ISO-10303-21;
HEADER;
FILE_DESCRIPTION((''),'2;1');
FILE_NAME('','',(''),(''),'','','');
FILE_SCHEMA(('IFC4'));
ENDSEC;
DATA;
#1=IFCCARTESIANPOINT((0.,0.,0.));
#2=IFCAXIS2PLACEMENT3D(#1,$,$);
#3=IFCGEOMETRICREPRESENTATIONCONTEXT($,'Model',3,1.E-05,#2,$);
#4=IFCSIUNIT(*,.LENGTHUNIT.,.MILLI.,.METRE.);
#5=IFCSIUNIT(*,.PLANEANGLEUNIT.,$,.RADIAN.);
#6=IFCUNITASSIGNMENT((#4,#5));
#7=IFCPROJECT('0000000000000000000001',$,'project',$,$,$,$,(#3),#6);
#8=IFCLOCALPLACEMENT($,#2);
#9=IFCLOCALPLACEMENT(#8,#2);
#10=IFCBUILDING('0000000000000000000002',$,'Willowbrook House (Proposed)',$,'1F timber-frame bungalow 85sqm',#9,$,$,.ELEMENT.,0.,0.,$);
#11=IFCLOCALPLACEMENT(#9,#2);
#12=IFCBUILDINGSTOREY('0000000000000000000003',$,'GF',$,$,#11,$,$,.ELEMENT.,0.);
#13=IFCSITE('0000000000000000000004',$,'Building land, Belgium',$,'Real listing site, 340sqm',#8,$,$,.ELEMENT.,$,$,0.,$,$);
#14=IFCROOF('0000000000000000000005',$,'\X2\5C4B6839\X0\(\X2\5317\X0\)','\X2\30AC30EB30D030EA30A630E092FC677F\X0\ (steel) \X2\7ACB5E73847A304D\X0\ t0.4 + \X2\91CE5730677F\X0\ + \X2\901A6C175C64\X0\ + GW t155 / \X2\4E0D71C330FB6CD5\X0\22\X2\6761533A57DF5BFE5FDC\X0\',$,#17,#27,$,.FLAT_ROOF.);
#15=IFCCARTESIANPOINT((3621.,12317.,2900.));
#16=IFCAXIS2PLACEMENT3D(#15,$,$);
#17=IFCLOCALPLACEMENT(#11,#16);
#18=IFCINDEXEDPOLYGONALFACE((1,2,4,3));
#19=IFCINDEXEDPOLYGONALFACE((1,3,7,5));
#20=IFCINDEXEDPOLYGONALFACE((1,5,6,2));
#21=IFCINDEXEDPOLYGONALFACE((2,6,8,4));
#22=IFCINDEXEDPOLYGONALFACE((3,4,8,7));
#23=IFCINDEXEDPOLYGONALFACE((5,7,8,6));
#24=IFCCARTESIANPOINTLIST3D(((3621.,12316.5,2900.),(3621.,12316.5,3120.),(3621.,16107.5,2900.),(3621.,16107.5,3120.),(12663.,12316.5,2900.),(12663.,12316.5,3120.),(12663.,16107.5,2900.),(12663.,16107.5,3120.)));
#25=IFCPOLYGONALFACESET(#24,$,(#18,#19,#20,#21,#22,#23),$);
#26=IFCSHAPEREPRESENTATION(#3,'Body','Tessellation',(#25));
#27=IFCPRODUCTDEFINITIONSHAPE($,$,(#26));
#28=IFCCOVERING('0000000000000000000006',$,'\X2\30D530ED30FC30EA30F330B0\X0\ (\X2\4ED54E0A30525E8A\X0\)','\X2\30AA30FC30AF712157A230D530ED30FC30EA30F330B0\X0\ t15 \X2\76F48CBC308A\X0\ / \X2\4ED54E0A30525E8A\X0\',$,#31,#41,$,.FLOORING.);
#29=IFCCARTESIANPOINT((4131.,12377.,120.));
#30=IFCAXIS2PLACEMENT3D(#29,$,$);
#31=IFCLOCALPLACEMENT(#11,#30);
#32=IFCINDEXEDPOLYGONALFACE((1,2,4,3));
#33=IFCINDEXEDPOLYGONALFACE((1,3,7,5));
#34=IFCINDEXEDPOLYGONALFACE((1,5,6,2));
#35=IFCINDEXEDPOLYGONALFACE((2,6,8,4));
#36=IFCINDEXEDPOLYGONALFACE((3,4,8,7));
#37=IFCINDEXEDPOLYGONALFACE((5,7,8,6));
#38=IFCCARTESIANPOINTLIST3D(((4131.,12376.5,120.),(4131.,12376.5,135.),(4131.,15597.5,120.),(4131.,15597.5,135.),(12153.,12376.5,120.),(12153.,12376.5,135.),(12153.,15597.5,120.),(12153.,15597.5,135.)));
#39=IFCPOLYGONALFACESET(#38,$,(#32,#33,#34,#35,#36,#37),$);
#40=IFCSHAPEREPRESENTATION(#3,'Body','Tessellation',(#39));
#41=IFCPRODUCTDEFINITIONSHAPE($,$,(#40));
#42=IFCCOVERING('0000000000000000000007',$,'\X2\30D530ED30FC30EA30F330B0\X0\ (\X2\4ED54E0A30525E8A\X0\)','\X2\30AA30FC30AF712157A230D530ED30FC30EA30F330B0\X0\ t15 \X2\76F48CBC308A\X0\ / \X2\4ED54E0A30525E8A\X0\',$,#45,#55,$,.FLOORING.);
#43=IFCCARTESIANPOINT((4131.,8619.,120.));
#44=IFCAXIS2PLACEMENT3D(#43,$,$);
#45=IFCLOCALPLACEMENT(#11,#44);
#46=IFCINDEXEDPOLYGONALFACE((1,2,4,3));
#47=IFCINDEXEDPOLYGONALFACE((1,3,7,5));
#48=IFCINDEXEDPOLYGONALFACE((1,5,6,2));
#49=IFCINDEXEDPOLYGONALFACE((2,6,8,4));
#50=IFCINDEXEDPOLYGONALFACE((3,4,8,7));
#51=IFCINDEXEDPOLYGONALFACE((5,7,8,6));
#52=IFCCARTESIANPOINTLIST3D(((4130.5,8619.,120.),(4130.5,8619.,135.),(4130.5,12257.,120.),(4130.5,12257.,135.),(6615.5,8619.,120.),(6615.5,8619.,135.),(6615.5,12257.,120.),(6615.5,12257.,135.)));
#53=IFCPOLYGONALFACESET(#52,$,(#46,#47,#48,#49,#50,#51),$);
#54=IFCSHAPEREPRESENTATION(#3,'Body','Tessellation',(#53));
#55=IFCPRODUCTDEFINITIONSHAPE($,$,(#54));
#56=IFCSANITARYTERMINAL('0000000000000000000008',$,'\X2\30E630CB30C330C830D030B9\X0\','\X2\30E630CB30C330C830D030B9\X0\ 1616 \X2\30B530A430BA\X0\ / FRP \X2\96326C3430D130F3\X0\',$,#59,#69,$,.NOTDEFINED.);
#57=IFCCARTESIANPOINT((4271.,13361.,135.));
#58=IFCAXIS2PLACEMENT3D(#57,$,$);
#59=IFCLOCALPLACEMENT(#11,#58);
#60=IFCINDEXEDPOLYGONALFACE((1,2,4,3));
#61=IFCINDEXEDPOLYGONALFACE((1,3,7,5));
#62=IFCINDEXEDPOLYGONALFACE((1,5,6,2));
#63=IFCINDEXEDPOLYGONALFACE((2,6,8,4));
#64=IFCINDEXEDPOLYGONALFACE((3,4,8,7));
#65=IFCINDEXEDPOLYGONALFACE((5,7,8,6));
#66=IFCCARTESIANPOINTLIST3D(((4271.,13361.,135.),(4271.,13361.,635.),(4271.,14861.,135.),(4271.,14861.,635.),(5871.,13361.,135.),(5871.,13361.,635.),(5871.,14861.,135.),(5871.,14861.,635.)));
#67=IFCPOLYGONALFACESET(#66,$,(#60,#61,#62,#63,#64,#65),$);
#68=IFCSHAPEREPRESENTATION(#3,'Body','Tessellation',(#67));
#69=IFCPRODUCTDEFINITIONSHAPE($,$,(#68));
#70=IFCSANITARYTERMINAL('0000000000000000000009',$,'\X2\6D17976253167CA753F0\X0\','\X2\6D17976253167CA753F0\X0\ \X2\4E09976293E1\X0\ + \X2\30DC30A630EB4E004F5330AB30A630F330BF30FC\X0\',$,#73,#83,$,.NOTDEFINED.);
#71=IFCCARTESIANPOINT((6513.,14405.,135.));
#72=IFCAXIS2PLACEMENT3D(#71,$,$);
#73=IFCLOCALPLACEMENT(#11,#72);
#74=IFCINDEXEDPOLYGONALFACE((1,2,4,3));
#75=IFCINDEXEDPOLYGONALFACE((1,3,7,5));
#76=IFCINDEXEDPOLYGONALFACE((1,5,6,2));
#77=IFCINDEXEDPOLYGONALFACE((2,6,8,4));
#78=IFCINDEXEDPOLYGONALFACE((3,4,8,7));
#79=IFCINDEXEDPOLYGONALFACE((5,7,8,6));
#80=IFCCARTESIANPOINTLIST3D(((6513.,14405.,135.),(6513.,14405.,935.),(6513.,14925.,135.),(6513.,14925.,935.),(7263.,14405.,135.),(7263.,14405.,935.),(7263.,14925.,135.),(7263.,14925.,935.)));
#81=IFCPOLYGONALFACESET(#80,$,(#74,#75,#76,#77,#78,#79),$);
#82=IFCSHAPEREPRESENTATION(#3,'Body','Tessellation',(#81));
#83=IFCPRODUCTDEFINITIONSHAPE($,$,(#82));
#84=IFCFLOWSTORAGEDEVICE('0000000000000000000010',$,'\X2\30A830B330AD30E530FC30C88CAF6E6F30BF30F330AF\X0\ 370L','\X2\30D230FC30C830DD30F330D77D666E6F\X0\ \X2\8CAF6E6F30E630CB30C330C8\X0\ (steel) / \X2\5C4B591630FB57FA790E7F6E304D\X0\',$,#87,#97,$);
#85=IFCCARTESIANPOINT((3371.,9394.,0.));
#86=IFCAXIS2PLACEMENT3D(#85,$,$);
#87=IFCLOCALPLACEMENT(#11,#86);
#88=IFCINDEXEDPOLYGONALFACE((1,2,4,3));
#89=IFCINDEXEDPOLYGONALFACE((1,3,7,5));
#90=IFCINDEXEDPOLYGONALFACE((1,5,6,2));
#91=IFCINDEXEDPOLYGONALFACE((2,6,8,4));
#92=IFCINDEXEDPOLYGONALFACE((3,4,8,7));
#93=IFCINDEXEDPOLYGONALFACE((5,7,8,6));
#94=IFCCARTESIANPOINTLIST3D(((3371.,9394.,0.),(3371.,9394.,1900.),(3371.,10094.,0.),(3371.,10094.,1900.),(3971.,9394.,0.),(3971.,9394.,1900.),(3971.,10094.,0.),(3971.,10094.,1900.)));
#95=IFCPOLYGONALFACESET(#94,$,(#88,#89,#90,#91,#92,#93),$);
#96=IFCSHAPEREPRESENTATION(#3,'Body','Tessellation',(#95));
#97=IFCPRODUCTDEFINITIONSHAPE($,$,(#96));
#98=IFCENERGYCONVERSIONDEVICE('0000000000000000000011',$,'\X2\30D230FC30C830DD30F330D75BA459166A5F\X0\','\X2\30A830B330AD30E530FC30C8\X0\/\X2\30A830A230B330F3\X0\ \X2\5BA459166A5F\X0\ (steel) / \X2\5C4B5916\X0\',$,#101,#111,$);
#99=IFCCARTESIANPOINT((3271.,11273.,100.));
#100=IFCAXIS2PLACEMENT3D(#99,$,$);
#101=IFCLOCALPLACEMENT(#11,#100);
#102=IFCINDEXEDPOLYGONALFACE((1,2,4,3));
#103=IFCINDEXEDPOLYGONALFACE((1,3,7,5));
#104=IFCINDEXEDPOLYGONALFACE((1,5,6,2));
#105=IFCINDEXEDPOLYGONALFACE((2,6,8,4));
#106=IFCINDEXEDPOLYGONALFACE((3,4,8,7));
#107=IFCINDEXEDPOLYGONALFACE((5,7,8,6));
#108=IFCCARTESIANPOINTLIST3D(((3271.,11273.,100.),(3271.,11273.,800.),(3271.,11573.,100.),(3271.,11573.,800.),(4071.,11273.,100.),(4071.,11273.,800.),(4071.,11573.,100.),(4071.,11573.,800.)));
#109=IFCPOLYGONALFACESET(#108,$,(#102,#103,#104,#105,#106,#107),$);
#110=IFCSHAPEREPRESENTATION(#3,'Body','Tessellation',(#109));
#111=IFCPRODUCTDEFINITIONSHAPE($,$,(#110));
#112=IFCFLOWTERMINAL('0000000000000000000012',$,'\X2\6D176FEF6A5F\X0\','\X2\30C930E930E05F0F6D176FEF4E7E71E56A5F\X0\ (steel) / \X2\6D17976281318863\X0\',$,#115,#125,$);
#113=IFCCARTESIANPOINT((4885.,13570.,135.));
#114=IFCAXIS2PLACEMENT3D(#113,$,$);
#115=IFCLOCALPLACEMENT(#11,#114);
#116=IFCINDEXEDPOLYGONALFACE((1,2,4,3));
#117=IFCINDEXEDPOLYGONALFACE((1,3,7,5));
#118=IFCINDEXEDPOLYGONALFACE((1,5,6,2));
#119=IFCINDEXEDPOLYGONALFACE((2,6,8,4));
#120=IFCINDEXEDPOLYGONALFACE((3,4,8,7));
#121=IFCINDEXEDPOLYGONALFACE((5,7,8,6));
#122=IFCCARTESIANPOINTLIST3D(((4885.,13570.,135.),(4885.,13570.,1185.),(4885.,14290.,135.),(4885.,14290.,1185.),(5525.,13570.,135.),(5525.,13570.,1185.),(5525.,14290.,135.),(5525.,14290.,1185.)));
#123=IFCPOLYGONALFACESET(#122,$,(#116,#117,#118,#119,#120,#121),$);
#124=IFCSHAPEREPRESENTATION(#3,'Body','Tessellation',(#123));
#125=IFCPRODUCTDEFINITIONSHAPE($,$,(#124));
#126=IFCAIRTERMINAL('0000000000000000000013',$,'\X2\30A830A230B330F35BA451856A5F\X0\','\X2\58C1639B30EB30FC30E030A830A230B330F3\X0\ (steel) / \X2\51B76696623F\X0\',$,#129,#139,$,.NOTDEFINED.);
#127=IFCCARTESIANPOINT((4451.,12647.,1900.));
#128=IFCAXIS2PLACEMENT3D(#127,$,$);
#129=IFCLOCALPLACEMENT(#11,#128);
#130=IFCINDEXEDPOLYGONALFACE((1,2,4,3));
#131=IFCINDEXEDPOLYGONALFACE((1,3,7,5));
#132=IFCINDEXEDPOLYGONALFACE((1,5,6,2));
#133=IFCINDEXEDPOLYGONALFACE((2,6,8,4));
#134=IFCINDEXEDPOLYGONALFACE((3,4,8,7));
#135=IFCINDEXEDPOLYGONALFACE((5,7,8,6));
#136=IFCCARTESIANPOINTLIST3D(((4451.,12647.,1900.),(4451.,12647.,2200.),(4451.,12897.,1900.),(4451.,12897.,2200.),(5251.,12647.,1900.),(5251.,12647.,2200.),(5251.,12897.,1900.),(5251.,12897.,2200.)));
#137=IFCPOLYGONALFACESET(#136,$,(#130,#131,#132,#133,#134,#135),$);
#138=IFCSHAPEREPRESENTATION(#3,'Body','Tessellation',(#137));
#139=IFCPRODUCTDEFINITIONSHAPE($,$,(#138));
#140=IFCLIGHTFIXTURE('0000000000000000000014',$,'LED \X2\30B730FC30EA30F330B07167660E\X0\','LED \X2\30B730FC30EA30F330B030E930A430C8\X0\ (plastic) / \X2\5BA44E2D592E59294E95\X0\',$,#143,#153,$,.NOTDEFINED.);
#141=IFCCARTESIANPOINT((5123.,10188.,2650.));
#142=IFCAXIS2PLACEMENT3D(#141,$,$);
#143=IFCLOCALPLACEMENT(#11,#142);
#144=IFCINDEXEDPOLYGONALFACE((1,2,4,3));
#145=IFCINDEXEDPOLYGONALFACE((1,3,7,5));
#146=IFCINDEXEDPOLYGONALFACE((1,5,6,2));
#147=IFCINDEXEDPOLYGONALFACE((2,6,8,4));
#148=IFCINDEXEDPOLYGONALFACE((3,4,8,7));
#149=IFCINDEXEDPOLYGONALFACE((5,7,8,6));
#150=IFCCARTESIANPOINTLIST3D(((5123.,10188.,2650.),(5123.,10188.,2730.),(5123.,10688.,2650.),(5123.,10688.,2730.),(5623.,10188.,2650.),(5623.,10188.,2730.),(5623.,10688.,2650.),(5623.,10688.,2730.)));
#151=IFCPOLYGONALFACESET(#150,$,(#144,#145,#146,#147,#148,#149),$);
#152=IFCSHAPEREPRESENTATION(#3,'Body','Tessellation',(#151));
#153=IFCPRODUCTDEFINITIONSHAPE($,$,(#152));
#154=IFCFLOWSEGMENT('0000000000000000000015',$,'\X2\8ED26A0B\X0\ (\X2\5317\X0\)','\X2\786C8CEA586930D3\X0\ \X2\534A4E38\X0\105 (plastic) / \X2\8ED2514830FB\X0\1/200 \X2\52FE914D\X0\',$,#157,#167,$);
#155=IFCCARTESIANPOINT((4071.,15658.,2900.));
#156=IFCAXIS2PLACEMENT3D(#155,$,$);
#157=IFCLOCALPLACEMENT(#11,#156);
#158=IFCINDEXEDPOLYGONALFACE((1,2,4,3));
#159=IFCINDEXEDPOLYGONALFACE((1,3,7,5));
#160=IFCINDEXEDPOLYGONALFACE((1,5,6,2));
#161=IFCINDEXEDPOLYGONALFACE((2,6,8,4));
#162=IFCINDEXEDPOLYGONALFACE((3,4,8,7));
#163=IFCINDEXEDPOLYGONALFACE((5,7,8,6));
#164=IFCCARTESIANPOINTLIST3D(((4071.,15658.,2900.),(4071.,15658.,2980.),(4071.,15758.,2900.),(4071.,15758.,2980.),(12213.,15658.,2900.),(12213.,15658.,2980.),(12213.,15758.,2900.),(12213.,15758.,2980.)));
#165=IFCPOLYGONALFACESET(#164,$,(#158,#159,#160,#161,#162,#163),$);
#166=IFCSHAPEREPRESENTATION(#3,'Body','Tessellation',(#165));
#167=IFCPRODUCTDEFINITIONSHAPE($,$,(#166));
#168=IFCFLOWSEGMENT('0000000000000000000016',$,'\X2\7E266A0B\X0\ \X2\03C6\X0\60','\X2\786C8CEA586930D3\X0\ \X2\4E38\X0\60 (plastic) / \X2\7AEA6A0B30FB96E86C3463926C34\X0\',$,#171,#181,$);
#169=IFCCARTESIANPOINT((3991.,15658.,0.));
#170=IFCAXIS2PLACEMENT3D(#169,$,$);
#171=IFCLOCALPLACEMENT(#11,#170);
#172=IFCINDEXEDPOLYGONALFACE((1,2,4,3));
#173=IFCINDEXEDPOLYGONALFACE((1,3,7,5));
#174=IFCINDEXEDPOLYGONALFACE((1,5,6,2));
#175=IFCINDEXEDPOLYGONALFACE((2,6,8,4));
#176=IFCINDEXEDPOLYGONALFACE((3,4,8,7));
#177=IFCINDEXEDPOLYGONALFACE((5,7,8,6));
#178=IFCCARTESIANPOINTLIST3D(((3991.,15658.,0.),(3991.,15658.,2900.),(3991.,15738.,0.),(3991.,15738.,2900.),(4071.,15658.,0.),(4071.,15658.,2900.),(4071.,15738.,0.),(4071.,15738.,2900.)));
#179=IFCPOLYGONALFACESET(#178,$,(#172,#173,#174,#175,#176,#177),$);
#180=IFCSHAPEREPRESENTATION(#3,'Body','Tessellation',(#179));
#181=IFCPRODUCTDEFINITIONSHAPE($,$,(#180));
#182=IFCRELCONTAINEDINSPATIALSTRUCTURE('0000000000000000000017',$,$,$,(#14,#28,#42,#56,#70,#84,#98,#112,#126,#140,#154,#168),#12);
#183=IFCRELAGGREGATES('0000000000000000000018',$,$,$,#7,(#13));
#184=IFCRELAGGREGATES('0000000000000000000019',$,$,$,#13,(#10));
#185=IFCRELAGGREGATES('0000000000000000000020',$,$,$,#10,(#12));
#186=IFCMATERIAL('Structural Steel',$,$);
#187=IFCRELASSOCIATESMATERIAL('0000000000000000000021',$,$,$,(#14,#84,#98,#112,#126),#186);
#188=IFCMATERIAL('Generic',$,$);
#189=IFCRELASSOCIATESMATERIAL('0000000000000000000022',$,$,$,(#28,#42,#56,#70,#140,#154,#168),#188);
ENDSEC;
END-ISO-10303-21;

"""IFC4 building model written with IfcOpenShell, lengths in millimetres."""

from ifc_helpers import new_model, si_unit, frame, frame_2d, origin, place, context, project, spatial, rectangle, extrude, material, element, save


model = new_model("IFC4")

# Units and contexts
model_context = context("Model", 3, precision=1e-05, world=origin())
ifc_project = project(units=[si_unit("LENGTHUNIT", "METRE", prefix="MILLI"), si_unit("PLANEANGLEUNIT", "RADIAN")], contexts=[model_context])

# Site, building, storey
site_placement = place(None, origin())
site = spatial("IfcSite", under=ifc_project, at=site_placement, Name="Building land, Belgium", ObjectType="Real listing site, 340sqm", CompositionType="ELEMENT", RefElevation=0.0)
building_placement = place(site_placement, origin())
building = spatial("IfcBuilding", under=site, at=building_placement, Name="Willowbrook House (Proposed)", ObjectType="1F timber-frame bungalow 85sqm", CompositionType="ELEMENT", ElevationOfRefHeight=0.0, ElevationOfTerrain=0.0)
storey_placement = place(building_placement, origin())
storey = spatial("IfcBuildingStorey", under=building, at=storey_placement, Name="GF", CompositionType="ELEMENT", Elevation=0.0)

# Roof
ifc_material_1 = material(Name="Structural Steel")
roof_placement = place(storey_placement, frame((3621.0, 12317.0, 2900.0)))
element("IfcRoof", 1, at=roof_placement, inside=storey, material=ifc_material_1, Name="屋根(北)", Description="ガルバリウム鋼板 (steel) 立平葺き t0.4 + 野地板 + 通気層 + GW t155 / 不燃・法22条区域対応", PredefinedType="FLAT_ROOF", context=model_context, shape_type="SweptSolid", body=[
    extrude(rectangle(XDim=9042.0, YDim=3791.0, at=frame_2d((4521.0, 1895.0))), frame((3621.0, 12317.0, 2900.0)), (0.0, 0.0, 1.0), 220.0),
])

# Coverings
ifc_material_2 = material(Name="Generic")
covering_1_placement = place(storey_placement, frame((4131.0, 12377.0, 120.0)))
element("IfcCovering", 2, at=covering_1_placement, inside=storey, material=ifc_material_2, Name="フローリング (仕上げ床)", Description="オーク無垢フローリング t15 直貼り / 仕上げ床", PredefinedType="FLOORING", context=model_context, shape_type="SweptSolid", body=[
    extrude(rectangle(XDim=8022.0, YDim=3221.0, at=frame_2d((4011.0, 1610.0))), frame((4131.0, 12377.0, 120.0)), (0.0, 0.0, 1.0), 15.0),
])
covering_2_placement = place(storey_placement, frame((4131.0, 8619.0, 120.0)))
element("IfcCovering", 3, at=covering_2_placement, inside=storey, material=ifc_material_2, Name="フローリング (仕上げ床)", Description="オーク無垢フローリング t15 直貼り / 仕上げ床", PredefinedType="FLOORING", context=model_context, shape_type="SweptSolid", body=[
    extrude(rectangle(XDim=2485.0, YDim=3638.0, at=frame_2d((1242.0, 1819.0))), frame((4131.0, 8619.0, 120.0)), (0.0, 0.0, 1.0), 15.0),
])

# Sanitary terminals
sanitary_terminal_1_placement = place(storey_placement, frame((4271.0, 13361.0, 135.0)))
element("IfcSanitaryTerminal", 4, at=sanitary_terminal_1_placement, inside=storey, material=ifc_material_2, Name="ユニットバス", Description="ユニットバス 1616 サイズ / FRP 防水パン", PredefinedType="NOTDEFINED", context=model_context, shape_type="SweptSolid", body=[
    extrude(rectangle(XDim=1600.0, YDim=1500.0, at=frame_2d((800.0, 750.0))), frame((4271.0, 13361.0, 135.0)), (0.0, 0.0, 1.0), 500.0),
])
sanitary_terminal_2_placement = place(storey_placement, frame((6513.0, 14405.0, 135.0)))
element("IfcSanitaryTerminal", 5, at=sanitary_terminal_2_placement, inside=storey, material=ifc_material_2, Name="洗面化粧台", Description="洗面化粧台 三面鏡 + ボウル一体カウンター", PredefinedType="NOTDEFINED", context=model_context, shape_type="SweptSolid", body=[
    extrude(rectangle(XDim=750.0, YDim=520.0, at=frame_2d((375.0, 260.0))), frame((6513.0, 14405.0, 135.0)), (0.0, 0.0, 1.0), 800.0),
])

# Flow storage device
flow_storage_device_placement = place(storey_placement, frame((3371.0, 9394.0, 0.0)))
element("IfcFlowStorageDevice", 6, at=flow_storage_device_placement, inside=storey, material=ifc_material_1, Name="エコキュート貯湯タンク 370L", Description="ヒートポンプ給湯 貯湯ユニット (steel) / 屋外・基礎置き", context=model_context, shape_type="SweptSolid", body=[
    extrude(rectangle(XDim=600.0, YDim=700.0, at=frame_2d((300.0, 350.0))), frame((3371.0, 9394.0, 0.0)), (0.0, 0.0, 1.0), 1900.0),
])

# Energy conversion device
energy_conversion_device_placement = place(storey_placement, frame((3271.0, 11273.0, 100.0)))
element("IfcEnergyConversionDevice", 7, at=energy_conversion_device_placement, inside=storey, material=ifc_material_1, Name="ヒートポンプ室外機", Description="エコキュート/エアコン 室外機 (steel) / 屋外", context=model_context, shape_type="SweptSolid", body=[
    extrude(rectangle(XDim=800.0, YDim=300.0, at=frame_2d((400.0, 150.0))), frame((3271.0, 11273.0, 100.0)), (0.0, 0.0, 1.0), 700.0),
])

# Flow terminal
flow_terminal_placement = place(storey_placement, frame((4885.0, 13570.0, 135.0)))
element("IfcFlowTerminal", 8, at=flow_terminal_placement, inside=storey, material=ifc_material_1, Name="洗濯機", Description="ドラム式洗濯乾燥機 (steel) / 洗面脱衣", context=model_context, shape_type="SweptSolid", body=[
    extrude(rectangle(XDim=640.0, YDim=720.0, at=frame_2d((320.0, 360.0))), frame((4885.0, 13570.0, 135.0)), (0.0, 0.0, 1.0), 1050.0),
])

# Air terminal
air_terminal_placement = place(storey_placement, frame((4451.0, 12647.0, 1900.0)))
element("IfcAirTerminal", 9, at=air_terminal_placement, inside=storey, material=ifc_material_1, Name="エアコン室内機", Description="壁掛ルームエアコン (steel) / 冷暖房", PredefinedType="NOTDEFINED", context=model_context, shape_type="SweptSolid", body=[
    extrude(rectangle(XDim=800.0, YDim=250.0, at=frame_2d((400.0, 125.0))), frame((4451.0, 12647.0, 1900.0)), (0.0, 0.0, 1.0), 300.0),
])

# Light fixture
light_fixture_placement = place(storey_placement, frame((5123.0, 10188.0, 2650.0)))
element("IfcLightFixture", 10, at=light_fixture_placement, inside=storey, material=ifc_material_2, Name="LED シーリング照明", Description="LED シーリングライト (plastic) / 室中央天井", PredefinedType="NOTDEFINED", context=model_context, shape_type="SweptSolid", body=[
    extrude(rectangle(XDim=500.0, YDim=500.0, at=frame_2d((250.0, 250.0))), frame((5123.0, 10188.0, 2650.0)), (0.0, 0.0, 1.0), 80.0),
])

# Flow segments
flow_segment_1_placement = place(storey_placement, frame((4071.0, 15658.0, 2900.0)))
element("IfcFlowSegment", 11, at=flow_segment_1_placement, inside=storey, material=ifc_material_2, Name="軒樋 (北)", Description="硬質塩ビ 半丸105 (plastic) / 軒先・1/200 勾配", context=model_context, shape_type="SweptSolid", body=[
    extrude(rectangle(XDim=8142.0, YDim=100.0, at=frame_2d((4071.0, 50.0))), frame((4071.0, 15658.0, 2900.0)), (0.0, 0.0, 1.0), 80.0),
])
flow_segment_2_placement = place(storey_placement, frame((3991.0, 15658.0, 0.0)))
element("IfcFlowSegment", 12, at=flow_segment_2_placement, inside=storey, material=ifc_material_2, Name="縦樋 φ60", Description="硬質塩ビ 丸60 (plastic) / 竪樋・雨水排水", context=model_context, shape_type="SweptSolid", body=[
    extrude(rectangle(XDim=80.0, YDim=80.0, at=frame_2d((40.0, 40.0))), frame((3991.0, 15658.0, 0.0)), (0.0, 0.0, 1.0), 2900.0),
])

save(model, "model.ifc")
